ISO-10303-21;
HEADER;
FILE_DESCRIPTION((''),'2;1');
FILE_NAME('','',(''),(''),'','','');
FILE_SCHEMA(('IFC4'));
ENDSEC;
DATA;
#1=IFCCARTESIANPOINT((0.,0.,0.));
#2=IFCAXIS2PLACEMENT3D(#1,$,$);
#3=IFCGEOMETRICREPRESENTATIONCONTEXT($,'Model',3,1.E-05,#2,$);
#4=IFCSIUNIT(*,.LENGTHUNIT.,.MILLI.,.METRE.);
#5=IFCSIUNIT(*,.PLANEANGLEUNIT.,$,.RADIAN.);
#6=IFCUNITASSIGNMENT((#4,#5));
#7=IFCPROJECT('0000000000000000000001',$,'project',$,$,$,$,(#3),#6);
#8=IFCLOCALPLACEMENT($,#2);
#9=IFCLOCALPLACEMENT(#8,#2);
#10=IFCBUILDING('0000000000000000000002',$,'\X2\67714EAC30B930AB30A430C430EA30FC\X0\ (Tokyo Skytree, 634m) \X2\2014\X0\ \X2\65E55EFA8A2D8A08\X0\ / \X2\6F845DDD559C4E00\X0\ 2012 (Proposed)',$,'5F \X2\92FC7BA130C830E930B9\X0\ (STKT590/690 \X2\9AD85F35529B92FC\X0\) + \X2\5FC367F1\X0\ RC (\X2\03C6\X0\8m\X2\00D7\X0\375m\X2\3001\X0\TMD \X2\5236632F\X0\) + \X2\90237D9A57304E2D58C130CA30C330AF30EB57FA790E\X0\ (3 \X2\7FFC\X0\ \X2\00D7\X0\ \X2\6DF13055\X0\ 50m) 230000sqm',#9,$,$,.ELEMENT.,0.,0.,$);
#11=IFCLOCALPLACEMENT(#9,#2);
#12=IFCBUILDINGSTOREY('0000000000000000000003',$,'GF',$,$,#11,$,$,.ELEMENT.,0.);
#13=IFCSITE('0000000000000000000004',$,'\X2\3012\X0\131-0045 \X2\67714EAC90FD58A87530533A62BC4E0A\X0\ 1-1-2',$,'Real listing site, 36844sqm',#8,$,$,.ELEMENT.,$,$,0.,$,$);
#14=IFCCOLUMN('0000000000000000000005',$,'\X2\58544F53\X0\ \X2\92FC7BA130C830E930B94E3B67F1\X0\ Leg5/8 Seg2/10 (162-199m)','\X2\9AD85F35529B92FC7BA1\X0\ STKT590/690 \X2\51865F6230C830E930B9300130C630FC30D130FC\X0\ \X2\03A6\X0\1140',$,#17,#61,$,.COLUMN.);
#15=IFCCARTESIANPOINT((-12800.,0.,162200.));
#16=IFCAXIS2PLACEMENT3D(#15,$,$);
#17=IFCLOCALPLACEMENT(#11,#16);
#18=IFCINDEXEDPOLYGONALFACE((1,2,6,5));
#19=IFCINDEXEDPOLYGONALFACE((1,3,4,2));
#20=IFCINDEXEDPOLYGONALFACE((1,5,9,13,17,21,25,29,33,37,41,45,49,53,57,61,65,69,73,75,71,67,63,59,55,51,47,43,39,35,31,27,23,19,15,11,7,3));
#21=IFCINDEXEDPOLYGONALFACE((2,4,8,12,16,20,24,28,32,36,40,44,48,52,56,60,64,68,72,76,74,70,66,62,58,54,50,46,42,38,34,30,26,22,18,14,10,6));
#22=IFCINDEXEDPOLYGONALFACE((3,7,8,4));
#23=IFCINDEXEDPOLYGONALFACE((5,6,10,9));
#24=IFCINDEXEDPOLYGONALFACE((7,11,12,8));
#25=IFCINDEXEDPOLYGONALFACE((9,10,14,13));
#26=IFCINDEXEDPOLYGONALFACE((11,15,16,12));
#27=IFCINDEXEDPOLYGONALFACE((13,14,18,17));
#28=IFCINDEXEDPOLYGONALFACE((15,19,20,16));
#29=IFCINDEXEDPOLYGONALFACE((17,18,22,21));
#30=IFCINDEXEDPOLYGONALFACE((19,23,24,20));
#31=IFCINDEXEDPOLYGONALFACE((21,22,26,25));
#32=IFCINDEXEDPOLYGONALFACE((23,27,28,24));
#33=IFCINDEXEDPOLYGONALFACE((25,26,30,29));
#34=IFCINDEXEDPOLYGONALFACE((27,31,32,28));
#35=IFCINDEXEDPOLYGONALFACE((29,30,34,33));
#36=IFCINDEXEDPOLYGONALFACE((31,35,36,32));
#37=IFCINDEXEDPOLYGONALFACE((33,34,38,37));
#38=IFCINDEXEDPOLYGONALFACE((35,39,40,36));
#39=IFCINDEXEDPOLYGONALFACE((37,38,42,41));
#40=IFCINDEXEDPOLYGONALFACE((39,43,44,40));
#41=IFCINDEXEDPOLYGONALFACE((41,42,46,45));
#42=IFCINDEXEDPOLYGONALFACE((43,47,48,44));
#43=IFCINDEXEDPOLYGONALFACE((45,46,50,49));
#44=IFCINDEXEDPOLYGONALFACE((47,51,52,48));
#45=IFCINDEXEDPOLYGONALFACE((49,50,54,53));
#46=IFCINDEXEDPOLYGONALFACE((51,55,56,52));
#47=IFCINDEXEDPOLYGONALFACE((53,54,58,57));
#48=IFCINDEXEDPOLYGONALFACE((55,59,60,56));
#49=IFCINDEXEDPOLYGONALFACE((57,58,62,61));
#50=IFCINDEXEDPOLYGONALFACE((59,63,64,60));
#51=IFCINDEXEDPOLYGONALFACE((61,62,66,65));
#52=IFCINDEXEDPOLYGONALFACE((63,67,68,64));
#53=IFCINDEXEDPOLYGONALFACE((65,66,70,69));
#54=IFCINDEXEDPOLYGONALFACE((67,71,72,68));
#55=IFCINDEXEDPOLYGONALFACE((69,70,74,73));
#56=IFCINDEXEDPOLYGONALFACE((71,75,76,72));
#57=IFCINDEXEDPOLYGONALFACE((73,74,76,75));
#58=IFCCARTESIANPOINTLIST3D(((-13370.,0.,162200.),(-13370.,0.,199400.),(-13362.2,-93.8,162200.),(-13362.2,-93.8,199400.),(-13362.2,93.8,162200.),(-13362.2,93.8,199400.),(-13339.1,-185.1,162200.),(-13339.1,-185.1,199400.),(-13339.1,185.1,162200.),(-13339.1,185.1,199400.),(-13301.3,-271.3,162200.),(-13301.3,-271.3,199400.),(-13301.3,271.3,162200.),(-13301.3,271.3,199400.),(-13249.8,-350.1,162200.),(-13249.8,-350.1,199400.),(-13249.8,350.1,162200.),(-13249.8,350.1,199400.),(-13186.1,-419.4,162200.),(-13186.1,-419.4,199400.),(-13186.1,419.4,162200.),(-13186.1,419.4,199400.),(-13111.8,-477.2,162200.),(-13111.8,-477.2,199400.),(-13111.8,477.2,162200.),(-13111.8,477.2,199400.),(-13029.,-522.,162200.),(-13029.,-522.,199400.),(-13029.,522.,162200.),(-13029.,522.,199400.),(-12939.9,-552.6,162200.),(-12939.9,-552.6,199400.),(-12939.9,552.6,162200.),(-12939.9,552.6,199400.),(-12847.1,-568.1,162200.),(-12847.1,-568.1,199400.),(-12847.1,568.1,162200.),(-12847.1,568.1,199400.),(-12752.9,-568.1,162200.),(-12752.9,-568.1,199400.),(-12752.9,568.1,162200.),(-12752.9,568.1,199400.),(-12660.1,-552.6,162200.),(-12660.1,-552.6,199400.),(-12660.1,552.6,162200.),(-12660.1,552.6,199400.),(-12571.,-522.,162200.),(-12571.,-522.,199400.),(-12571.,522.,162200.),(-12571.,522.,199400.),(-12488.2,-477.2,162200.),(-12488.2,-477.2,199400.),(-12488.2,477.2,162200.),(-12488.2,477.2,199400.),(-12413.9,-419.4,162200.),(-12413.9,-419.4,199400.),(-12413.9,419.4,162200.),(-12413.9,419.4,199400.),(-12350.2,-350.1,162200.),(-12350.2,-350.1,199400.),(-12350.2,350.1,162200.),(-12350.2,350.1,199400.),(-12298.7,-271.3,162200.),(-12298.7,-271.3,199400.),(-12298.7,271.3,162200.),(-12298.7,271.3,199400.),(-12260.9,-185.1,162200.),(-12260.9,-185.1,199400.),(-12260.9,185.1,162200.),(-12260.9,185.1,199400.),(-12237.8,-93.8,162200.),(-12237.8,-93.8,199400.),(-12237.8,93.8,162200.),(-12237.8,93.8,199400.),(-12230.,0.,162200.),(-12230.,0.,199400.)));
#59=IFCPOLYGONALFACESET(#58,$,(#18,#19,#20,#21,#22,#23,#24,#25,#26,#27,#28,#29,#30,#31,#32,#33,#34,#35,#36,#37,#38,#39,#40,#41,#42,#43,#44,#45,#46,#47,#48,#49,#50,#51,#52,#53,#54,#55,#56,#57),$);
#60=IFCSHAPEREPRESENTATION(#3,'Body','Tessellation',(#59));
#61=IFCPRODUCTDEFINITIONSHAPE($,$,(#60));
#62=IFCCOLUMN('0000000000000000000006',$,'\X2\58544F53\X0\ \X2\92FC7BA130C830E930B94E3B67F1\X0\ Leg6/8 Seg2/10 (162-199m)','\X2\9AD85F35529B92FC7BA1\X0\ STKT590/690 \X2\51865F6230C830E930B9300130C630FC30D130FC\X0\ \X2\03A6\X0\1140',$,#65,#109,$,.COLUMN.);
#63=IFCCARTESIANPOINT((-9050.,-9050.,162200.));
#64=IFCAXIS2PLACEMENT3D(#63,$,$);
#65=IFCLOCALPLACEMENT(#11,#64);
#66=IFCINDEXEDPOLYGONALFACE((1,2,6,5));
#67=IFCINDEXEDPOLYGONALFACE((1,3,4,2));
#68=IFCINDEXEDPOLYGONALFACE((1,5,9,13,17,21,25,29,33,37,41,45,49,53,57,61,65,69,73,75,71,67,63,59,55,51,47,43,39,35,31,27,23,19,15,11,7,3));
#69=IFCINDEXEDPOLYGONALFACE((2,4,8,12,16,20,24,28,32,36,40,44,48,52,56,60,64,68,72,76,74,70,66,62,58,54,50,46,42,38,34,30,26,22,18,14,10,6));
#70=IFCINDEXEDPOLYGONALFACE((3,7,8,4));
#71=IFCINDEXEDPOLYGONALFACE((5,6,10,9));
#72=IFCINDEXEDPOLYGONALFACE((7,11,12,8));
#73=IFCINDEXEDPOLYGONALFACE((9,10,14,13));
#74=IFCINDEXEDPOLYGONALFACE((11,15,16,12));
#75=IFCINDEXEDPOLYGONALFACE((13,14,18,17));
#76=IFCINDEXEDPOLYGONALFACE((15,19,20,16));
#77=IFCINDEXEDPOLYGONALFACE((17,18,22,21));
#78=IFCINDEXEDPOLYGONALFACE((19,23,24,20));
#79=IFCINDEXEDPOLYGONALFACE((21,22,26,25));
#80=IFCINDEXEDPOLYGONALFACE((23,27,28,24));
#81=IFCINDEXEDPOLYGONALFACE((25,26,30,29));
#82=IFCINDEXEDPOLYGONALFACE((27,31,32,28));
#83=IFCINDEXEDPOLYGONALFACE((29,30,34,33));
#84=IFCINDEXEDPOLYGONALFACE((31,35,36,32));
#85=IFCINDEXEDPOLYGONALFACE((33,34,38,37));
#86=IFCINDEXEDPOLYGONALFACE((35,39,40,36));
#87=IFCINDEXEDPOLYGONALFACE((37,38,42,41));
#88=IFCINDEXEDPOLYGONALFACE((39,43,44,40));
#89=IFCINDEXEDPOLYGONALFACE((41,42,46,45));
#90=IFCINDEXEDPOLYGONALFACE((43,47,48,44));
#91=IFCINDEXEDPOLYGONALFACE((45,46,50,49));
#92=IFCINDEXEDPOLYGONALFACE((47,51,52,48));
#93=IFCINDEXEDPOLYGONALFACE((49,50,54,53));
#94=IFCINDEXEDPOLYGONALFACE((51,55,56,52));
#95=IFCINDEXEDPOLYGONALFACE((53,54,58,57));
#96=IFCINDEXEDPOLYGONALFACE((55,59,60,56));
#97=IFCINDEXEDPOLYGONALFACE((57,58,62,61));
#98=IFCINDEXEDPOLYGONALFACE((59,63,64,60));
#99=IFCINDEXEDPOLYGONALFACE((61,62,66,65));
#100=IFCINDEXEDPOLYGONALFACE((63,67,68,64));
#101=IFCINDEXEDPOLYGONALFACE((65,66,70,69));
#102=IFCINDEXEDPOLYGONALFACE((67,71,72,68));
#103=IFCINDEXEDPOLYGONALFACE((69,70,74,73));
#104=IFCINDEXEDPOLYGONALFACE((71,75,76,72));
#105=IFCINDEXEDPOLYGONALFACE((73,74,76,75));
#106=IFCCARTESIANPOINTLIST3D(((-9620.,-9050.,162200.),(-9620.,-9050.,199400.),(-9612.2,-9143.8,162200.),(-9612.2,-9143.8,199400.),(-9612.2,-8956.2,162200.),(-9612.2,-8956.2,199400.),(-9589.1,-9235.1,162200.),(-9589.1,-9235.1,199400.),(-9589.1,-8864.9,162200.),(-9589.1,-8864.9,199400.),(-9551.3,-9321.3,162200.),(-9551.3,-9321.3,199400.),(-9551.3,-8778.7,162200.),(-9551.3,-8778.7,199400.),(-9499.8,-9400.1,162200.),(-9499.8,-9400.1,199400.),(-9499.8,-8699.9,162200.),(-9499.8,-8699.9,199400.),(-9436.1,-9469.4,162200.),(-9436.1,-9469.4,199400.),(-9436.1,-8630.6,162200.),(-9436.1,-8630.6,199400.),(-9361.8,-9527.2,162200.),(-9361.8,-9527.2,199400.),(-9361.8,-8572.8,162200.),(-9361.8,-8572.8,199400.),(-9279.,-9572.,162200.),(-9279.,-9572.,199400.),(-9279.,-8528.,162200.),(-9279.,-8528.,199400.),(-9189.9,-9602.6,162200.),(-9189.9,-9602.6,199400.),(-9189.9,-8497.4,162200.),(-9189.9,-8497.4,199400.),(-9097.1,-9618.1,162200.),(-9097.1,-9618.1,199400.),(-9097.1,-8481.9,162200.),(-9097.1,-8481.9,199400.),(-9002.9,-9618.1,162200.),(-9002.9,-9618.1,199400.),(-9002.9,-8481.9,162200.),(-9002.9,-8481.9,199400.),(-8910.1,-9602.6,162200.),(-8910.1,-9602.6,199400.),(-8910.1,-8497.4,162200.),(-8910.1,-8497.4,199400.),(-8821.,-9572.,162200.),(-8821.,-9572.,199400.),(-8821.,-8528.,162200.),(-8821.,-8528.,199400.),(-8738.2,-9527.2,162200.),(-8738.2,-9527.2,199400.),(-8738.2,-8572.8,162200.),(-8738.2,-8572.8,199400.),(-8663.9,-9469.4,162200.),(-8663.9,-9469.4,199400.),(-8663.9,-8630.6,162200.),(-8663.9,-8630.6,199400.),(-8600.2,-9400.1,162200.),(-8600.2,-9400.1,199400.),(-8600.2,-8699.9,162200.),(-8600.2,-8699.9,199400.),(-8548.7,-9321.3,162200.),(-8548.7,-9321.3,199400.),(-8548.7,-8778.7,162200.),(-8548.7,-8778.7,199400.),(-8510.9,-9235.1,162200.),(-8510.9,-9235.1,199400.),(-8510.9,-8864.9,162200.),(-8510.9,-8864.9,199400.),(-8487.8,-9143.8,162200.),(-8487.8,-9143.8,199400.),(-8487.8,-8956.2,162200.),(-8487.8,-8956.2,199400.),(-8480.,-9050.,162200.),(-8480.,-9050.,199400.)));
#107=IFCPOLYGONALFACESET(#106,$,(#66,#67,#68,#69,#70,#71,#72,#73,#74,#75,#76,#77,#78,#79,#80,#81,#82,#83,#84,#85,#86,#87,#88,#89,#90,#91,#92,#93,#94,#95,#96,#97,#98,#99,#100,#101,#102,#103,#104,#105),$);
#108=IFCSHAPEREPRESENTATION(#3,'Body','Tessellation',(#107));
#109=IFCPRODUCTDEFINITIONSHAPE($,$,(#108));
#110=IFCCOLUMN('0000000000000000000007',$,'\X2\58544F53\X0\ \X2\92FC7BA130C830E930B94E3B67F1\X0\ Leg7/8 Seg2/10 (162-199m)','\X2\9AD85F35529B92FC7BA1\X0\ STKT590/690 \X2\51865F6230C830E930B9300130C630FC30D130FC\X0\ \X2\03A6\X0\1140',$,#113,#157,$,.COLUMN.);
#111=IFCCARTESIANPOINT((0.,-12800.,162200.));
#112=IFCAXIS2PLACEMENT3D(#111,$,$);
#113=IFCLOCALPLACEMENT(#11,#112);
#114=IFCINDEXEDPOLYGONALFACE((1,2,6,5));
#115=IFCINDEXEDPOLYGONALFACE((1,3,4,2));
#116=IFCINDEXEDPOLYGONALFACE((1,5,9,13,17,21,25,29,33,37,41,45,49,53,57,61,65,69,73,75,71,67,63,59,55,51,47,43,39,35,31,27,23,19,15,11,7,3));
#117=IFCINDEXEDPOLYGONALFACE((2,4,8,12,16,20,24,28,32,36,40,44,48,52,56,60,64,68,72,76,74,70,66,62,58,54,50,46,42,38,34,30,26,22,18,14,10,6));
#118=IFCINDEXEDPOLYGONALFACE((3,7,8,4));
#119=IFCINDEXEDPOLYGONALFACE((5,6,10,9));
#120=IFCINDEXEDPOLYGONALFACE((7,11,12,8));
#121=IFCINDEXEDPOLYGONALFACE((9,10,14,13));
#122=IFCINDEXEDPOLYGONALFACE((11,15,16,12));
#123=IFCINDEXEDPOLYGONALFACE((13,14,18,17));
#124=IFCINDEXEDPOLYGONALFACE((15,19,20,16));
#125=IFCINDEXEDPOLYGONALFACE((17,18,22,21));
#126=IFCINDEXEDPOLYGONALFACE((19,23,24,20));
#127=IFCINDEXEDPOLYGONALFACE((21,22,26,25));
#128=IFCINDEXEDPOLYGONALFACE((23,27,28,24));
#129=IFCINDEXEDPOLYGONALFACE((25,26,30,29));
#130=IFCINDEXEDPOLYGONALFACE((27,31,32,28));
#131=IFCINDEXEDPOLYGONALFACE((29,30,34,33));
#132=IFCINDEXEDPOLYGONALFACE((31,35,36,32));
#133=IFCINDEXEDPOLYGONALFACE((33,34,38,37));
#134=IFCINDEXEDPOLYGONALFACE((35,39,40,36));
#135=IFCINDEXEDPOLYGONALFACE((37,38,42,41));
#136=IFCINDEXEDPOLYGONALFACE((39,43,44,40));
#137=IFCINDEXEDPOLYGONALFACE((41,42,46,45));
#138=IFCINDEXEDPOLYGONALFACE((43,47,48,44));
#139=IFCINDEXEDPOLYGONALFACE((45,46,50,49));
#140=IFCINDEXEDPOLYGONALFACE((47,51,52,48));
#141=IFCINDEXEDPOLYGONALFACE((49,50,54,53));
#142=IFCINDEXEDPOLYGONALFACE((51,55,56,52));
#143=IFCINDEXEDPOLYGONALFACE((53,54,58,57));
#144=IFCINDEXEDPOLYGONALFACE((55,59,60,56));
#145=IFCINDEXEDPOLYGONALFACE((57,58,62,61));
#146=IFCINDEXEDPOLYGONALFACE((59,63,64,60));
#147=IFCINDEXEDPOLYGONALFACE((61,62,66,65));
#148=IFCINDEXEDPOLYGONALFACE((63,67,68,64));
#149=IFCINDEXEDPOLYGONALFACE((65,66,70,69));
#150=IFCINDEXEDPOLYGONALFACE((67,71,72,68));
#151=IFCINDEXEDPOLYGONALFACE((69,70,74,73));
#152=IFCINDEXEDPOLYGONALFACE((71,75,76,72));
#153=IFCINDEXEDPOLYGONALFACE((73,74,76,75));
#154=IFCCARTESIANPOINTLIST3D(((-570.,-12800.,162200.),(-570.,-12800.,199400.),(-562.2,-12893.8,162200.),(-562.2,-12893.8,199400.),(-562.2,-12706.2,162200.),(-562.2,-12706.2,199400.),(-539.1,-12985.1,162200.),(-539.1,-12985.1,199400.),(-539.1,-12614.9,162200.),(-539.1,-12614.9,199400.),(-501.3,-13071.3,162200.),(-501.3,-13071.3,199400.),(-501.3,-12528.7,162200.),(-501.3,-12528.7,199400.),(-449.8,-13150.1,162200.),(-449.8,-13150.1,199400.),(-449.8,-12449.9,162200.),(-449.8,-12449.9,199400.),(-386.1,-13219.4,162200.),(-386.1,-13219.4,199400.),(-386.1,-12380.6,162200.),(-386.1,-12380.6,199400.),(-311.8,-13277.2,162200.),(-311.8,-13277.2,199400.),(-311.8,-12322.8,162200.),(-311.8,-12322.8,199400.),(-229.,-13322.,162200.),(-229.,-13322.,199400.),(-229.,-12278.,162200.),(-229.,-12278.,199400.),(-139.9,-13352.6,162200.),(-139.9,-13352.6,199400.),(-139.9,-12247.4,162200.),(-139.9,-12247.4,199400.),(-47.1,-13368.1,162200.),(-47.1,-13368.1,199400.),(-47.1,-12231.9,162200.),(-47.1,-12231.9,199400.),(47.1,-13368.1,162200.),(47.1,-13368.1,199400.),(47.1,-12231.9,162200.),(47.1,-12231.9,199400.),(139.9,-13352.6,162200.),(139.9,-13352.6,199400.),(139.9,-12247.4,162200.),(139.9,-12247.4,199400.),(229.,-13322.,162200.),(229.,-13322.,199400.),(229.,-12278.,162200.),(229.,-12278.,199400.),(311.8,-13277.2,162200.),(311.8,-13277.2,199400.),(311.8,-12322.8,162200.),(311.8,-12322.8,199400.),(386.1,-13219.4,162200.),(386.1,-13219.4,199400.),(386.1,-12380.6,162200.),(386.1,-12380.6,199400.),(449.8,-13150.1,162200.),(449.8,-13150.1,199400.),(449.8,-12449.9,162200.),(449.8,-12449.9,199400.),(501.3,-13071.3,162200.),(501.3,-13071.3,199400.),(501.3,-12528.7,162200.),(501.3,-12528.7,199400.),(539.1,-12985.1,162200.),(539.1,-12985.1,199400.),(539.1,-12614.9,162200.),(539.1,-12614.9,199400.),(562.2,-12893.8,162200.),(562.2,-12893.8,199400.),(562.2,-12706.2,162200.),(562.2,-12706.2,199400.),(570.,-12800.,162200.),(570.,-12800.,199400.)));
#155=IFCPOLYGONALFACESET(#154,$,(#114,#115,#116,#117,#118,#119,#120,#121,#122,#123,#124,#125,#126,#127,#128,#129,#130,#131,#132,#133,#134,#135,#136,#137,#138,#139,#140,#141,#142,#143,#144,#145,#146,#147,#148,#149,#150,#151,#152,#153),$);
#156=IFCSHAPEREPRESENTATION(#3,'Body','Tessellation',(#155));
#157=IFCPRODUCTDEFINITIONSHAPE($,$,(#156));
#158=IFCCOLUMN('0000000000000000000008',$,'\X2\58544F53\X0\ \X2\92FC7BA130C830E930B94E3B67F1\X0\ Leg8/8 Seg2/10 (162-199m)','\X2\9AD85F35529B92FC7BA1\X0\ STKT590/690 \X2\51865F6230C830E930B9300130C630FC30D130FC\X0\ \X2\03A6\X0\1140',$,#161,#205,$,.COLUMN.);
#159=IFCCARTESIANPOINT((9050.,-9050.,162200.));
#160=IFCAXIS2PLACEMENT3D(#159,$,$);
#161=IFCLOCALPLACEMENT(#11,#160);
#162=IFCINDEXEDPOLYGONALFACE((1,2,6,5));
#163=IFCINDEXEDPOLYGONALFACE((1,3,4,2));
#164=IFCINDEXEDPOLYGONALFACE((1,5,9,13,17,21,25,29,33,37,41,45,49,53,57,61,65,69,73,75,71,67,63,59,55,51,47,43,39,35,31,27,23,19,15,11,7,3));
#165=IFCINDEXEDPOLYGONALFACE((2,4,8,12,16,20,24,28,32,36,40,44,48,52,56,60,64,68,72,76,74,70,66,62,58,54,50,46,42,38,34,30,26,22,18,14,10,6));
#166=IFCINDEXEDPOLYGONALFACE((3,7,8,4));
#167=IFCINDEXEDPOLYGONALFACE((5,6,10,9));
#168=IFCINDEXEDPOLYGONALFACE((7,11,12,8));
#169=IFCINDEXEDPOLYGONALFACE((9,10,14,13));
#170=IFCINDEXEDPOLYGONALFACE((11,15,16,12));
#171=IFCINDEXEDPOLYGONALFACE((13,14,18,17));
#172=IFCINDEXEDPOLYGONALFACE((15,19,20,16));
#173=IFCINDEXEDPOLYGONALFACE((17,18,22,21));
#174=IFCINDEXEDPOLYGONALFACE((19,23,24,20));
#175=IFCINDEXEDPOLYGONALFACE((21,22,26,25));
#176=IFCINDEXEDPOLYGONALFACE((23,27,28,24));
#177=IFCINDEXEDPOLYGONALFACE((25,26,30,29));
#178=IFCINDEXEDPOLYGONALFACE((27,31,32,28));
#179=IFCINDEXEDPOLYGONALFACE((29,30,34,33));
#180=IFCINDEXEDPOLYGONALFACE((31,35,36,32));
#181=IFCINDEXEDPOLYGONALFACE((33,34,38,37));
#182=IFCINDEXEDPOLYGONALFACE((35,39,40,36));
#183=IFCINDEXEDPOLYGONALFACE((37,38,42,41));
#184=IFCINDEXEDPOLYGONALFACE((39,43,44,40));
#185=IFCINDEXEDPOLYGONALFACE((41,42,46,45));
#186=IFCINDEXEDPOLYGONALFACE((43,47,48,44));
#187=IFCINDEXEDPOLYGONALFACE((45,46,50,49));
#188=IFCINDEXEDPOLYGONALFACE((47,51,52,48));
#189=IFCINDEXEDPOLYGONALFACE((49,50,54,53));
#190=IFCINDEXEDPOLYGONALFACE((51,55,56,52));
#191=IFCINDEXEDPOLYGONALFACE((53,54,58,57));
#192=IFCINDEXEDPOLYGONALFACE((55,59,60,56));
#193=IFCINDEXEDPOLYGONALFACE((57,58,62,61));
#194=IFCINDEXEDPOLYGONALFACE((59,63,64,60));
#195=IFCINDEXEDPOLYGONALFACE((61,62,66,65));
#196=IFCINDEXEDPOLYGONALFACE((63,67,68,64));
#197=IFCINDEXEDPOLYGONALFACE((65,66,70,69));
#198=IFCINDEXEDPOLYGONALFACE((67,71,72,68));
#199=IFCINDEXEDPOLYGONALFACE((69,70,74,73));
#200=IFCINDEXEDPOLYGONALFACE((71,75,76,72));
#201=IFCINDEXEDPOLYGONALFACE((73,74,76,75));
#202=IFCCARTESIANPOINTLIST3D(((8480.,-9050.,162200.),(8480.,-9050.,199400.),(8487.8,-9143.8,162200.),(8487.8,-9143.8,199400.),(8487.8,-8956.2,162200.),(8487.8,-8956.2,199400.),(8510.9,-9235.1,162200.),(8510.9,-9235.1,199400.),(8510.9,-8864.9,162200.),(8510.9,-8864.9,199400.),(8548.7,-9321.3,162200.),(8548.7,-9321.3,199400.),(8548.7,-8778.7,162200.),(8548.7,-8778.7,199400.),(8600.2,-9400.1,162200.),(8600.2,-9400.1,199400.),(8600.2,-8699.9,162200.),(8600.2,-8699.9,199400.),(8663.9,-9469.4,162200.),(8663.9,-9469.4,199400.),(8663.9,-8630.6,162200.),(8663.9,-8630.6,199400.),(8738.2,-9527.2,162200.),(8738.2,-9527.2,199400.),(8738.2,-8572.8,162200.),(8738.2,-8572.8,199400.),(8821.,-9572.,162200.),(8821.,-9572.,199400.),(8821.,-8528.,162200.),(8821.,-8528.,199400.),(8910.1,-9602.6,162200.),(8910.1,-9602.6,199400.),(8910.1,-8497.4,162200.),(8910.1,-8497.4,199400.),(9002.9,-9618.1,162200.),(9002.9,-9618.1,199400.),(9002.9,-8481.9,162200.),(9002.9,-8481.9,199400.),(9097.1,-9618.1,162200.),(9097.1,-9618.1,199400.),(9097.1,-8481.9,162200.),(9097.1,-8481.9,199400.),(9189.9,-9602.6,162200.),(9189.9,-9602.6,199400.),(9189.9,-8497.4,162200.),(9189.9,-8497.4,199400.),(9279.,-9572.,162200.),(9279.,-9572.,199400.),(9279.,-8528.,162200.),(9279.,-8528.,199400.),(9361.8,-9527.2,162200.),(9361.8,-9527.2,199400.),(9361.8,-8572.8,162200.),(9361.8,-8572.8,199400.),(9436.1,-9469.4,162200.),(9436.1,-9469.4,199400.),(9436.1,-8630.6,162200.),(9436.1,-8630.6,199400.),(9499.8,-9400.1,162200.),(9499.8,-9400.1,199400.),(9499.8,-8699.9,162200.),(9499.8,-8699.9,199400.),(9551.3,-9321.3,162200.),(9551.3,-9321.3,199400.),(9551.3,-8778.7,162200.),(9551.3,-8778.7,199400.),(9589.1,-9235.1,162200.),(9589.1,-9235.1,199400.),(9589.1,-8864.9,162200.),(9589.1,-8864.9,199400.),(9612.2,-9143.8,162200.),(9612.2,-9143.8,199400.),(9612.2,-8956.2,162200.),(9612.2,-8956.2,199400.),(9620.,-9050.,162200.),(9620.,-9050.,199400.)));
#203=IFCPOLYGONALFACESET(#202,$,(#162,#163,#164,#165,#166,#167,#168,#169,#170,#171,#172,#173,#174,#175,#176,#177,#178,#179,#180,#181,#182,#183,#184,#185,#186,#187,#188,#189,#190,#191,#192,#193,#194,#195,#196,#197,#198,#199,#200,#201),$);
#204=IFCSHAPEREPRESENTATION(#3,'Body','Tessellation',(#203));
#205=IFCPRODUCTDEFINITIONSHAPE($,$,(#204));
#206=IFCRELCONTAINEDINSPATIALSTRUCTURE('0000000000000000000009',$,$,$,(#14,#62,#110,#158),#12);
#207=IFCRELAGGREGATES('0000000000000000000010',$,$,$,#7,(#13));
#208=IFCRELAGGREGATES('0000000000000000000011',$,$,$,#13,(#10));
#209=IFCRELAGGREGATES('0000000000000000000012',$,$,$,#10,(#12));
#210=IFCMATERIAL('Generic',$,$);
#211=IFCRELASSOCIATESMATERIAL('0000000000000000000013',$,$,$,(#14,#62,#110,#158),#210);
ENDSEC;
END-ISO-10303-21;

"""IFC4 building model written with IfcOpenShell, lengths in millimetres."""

from ifc_helpers import new_model, si_unit, frame, origin, origin_2d, place, context, project, spatial, circle, extrude, material, element, save


model = new_model("IFC4")

# Units and contexts
model_context = context("Model", 3, precision=1e-05, world=origin())
ifc_project = project(units=[si_unit("LENGTHUNIT", "METRE", prefix="MILLI"), si_unit("PLANEANGLEUNIT", "RADIAN")], contexts=[model_context])

# Site, building, storey
site_placement = place(None, origin())
site = spatial("IfcSite", under=ifc_project, at=site_placement, Name="〒131-0045 東京都墨田区押上 1-1-2", ObjectType="Real listing site, 36844sqm", CompositionType="ELEMENT", RefElevation=0.0)
building_placement = place(site_placement, origin())
building = spatial("IfcBuilding", under=site, at=building_placement, Name="東京スカイツリー (Tokyo Skytree, 634m) — 日建設計 / 澄川喜一 2012 (Proposed)", ObjectType="5F 鋼管トラス (STKT590/690 高張力鋼) + 心柱 RC (φ8m×375m、TMD 制振) + 連続地中壁ナックル基礎 (3 翼 × 深さ 50m) 230000sqm", CompositionType="ELEMENT", ElevationOfRefHeight=0.0, ElevationOfTerrain=0.0)
storey_placement = place(building_placement, origin())
storey = spatial("IfcBuildingStorey", under=building, at=storey_placement, Name="GF", CompositionType="ELEMENT", Elevation=0.0)

# Columns
ifc_material = material(Name="Generic")
column_1_placement = place(storey_placement, frame((-12800.0, 0.0, 162200.0)))
element("IfcColumn", 1, at=column_1_placement, inside=storey, material=ifc_material, Name="塔体 鋼管トラス主柱 Leg5/8 Seg2/10 (162-199m)", Description="高張力鋼管 STKT590/690 円形トラス、テーパー Φ1140", PredefinedType="COLUMN", context=model_context, shape_type="SweptSolid", body=[
    extrude(circle(Radius=570.0, at=origin_2d()), frame((-12800.0, 0.0, 162200.0)), (0.0, 0.0, 1.0), 37200.0),
])
column_2_placement = place(storey_placement, frame((-9050.0, -9050.0, 162200.0)))
element("IfcColumn", 2, at=column_2_placement, inside=storey, material=ifc_material, Name="塔体 鋼管トラス主柱 Leg6/8 Seg2/10 (162-199m)", Description="高張力鋼管 STKT590/690 円形トラス、テーパー Φ1140", PredefinedType="COLUMN", context=model_context, shape_type="SweptSolid", body=[
    extrude(circle(Radius=570.0, at=origin_2d()), frame((-9050.0, -9050.0, 162200.0)), (0.0, 0.0, 1.0), 37200.0),
])
column_3_placement = place(storey_placement, frame((0.0, -12800.0, 162200.0)))
element("IfcColumn", 3, at=column_3_placement, inside=storey, material=ifc_material, Name="塔体 鋼管トラス主柱 Leg7/8 Seg2/10 (162-199m)", Description="高張力鋼管 STKT590/690 円形トラス、テーパー Φ1140", PredefinedType="COLUMN", context=model_context, shape_type="SweptSolid", body=[
    extrude(circle(Radius=570.0, at=origin_2d()), frame((0.0, -12800.0, 162200.0)), (0.0, 0.0, 1.0), 37200.0),
])
column_4_placement = place(storey_placement, frame((9050.0, -9050.0, 162200.0)))
element("IfcColumn", 4, at=column_4_placement, inside=storey, material=ifc_material, Name="塔体 鋼管トラス主柱 Leg8/8 Seg2/10 (162-199m)", Description="高張力鋼管 STKT590/690 円形トラス、テーパー Φ1140", PredefinedType="COLUMN", context=model_context, shape_type="SweptSolid", body=[
    extrude(circle(Radius=570.0, at=origin_2d()), frame((9050.0, -9050.0, 162200.0)), (0.0, 0.0, 1.0), 37200.0),
])

save(model, "model.ifc")
